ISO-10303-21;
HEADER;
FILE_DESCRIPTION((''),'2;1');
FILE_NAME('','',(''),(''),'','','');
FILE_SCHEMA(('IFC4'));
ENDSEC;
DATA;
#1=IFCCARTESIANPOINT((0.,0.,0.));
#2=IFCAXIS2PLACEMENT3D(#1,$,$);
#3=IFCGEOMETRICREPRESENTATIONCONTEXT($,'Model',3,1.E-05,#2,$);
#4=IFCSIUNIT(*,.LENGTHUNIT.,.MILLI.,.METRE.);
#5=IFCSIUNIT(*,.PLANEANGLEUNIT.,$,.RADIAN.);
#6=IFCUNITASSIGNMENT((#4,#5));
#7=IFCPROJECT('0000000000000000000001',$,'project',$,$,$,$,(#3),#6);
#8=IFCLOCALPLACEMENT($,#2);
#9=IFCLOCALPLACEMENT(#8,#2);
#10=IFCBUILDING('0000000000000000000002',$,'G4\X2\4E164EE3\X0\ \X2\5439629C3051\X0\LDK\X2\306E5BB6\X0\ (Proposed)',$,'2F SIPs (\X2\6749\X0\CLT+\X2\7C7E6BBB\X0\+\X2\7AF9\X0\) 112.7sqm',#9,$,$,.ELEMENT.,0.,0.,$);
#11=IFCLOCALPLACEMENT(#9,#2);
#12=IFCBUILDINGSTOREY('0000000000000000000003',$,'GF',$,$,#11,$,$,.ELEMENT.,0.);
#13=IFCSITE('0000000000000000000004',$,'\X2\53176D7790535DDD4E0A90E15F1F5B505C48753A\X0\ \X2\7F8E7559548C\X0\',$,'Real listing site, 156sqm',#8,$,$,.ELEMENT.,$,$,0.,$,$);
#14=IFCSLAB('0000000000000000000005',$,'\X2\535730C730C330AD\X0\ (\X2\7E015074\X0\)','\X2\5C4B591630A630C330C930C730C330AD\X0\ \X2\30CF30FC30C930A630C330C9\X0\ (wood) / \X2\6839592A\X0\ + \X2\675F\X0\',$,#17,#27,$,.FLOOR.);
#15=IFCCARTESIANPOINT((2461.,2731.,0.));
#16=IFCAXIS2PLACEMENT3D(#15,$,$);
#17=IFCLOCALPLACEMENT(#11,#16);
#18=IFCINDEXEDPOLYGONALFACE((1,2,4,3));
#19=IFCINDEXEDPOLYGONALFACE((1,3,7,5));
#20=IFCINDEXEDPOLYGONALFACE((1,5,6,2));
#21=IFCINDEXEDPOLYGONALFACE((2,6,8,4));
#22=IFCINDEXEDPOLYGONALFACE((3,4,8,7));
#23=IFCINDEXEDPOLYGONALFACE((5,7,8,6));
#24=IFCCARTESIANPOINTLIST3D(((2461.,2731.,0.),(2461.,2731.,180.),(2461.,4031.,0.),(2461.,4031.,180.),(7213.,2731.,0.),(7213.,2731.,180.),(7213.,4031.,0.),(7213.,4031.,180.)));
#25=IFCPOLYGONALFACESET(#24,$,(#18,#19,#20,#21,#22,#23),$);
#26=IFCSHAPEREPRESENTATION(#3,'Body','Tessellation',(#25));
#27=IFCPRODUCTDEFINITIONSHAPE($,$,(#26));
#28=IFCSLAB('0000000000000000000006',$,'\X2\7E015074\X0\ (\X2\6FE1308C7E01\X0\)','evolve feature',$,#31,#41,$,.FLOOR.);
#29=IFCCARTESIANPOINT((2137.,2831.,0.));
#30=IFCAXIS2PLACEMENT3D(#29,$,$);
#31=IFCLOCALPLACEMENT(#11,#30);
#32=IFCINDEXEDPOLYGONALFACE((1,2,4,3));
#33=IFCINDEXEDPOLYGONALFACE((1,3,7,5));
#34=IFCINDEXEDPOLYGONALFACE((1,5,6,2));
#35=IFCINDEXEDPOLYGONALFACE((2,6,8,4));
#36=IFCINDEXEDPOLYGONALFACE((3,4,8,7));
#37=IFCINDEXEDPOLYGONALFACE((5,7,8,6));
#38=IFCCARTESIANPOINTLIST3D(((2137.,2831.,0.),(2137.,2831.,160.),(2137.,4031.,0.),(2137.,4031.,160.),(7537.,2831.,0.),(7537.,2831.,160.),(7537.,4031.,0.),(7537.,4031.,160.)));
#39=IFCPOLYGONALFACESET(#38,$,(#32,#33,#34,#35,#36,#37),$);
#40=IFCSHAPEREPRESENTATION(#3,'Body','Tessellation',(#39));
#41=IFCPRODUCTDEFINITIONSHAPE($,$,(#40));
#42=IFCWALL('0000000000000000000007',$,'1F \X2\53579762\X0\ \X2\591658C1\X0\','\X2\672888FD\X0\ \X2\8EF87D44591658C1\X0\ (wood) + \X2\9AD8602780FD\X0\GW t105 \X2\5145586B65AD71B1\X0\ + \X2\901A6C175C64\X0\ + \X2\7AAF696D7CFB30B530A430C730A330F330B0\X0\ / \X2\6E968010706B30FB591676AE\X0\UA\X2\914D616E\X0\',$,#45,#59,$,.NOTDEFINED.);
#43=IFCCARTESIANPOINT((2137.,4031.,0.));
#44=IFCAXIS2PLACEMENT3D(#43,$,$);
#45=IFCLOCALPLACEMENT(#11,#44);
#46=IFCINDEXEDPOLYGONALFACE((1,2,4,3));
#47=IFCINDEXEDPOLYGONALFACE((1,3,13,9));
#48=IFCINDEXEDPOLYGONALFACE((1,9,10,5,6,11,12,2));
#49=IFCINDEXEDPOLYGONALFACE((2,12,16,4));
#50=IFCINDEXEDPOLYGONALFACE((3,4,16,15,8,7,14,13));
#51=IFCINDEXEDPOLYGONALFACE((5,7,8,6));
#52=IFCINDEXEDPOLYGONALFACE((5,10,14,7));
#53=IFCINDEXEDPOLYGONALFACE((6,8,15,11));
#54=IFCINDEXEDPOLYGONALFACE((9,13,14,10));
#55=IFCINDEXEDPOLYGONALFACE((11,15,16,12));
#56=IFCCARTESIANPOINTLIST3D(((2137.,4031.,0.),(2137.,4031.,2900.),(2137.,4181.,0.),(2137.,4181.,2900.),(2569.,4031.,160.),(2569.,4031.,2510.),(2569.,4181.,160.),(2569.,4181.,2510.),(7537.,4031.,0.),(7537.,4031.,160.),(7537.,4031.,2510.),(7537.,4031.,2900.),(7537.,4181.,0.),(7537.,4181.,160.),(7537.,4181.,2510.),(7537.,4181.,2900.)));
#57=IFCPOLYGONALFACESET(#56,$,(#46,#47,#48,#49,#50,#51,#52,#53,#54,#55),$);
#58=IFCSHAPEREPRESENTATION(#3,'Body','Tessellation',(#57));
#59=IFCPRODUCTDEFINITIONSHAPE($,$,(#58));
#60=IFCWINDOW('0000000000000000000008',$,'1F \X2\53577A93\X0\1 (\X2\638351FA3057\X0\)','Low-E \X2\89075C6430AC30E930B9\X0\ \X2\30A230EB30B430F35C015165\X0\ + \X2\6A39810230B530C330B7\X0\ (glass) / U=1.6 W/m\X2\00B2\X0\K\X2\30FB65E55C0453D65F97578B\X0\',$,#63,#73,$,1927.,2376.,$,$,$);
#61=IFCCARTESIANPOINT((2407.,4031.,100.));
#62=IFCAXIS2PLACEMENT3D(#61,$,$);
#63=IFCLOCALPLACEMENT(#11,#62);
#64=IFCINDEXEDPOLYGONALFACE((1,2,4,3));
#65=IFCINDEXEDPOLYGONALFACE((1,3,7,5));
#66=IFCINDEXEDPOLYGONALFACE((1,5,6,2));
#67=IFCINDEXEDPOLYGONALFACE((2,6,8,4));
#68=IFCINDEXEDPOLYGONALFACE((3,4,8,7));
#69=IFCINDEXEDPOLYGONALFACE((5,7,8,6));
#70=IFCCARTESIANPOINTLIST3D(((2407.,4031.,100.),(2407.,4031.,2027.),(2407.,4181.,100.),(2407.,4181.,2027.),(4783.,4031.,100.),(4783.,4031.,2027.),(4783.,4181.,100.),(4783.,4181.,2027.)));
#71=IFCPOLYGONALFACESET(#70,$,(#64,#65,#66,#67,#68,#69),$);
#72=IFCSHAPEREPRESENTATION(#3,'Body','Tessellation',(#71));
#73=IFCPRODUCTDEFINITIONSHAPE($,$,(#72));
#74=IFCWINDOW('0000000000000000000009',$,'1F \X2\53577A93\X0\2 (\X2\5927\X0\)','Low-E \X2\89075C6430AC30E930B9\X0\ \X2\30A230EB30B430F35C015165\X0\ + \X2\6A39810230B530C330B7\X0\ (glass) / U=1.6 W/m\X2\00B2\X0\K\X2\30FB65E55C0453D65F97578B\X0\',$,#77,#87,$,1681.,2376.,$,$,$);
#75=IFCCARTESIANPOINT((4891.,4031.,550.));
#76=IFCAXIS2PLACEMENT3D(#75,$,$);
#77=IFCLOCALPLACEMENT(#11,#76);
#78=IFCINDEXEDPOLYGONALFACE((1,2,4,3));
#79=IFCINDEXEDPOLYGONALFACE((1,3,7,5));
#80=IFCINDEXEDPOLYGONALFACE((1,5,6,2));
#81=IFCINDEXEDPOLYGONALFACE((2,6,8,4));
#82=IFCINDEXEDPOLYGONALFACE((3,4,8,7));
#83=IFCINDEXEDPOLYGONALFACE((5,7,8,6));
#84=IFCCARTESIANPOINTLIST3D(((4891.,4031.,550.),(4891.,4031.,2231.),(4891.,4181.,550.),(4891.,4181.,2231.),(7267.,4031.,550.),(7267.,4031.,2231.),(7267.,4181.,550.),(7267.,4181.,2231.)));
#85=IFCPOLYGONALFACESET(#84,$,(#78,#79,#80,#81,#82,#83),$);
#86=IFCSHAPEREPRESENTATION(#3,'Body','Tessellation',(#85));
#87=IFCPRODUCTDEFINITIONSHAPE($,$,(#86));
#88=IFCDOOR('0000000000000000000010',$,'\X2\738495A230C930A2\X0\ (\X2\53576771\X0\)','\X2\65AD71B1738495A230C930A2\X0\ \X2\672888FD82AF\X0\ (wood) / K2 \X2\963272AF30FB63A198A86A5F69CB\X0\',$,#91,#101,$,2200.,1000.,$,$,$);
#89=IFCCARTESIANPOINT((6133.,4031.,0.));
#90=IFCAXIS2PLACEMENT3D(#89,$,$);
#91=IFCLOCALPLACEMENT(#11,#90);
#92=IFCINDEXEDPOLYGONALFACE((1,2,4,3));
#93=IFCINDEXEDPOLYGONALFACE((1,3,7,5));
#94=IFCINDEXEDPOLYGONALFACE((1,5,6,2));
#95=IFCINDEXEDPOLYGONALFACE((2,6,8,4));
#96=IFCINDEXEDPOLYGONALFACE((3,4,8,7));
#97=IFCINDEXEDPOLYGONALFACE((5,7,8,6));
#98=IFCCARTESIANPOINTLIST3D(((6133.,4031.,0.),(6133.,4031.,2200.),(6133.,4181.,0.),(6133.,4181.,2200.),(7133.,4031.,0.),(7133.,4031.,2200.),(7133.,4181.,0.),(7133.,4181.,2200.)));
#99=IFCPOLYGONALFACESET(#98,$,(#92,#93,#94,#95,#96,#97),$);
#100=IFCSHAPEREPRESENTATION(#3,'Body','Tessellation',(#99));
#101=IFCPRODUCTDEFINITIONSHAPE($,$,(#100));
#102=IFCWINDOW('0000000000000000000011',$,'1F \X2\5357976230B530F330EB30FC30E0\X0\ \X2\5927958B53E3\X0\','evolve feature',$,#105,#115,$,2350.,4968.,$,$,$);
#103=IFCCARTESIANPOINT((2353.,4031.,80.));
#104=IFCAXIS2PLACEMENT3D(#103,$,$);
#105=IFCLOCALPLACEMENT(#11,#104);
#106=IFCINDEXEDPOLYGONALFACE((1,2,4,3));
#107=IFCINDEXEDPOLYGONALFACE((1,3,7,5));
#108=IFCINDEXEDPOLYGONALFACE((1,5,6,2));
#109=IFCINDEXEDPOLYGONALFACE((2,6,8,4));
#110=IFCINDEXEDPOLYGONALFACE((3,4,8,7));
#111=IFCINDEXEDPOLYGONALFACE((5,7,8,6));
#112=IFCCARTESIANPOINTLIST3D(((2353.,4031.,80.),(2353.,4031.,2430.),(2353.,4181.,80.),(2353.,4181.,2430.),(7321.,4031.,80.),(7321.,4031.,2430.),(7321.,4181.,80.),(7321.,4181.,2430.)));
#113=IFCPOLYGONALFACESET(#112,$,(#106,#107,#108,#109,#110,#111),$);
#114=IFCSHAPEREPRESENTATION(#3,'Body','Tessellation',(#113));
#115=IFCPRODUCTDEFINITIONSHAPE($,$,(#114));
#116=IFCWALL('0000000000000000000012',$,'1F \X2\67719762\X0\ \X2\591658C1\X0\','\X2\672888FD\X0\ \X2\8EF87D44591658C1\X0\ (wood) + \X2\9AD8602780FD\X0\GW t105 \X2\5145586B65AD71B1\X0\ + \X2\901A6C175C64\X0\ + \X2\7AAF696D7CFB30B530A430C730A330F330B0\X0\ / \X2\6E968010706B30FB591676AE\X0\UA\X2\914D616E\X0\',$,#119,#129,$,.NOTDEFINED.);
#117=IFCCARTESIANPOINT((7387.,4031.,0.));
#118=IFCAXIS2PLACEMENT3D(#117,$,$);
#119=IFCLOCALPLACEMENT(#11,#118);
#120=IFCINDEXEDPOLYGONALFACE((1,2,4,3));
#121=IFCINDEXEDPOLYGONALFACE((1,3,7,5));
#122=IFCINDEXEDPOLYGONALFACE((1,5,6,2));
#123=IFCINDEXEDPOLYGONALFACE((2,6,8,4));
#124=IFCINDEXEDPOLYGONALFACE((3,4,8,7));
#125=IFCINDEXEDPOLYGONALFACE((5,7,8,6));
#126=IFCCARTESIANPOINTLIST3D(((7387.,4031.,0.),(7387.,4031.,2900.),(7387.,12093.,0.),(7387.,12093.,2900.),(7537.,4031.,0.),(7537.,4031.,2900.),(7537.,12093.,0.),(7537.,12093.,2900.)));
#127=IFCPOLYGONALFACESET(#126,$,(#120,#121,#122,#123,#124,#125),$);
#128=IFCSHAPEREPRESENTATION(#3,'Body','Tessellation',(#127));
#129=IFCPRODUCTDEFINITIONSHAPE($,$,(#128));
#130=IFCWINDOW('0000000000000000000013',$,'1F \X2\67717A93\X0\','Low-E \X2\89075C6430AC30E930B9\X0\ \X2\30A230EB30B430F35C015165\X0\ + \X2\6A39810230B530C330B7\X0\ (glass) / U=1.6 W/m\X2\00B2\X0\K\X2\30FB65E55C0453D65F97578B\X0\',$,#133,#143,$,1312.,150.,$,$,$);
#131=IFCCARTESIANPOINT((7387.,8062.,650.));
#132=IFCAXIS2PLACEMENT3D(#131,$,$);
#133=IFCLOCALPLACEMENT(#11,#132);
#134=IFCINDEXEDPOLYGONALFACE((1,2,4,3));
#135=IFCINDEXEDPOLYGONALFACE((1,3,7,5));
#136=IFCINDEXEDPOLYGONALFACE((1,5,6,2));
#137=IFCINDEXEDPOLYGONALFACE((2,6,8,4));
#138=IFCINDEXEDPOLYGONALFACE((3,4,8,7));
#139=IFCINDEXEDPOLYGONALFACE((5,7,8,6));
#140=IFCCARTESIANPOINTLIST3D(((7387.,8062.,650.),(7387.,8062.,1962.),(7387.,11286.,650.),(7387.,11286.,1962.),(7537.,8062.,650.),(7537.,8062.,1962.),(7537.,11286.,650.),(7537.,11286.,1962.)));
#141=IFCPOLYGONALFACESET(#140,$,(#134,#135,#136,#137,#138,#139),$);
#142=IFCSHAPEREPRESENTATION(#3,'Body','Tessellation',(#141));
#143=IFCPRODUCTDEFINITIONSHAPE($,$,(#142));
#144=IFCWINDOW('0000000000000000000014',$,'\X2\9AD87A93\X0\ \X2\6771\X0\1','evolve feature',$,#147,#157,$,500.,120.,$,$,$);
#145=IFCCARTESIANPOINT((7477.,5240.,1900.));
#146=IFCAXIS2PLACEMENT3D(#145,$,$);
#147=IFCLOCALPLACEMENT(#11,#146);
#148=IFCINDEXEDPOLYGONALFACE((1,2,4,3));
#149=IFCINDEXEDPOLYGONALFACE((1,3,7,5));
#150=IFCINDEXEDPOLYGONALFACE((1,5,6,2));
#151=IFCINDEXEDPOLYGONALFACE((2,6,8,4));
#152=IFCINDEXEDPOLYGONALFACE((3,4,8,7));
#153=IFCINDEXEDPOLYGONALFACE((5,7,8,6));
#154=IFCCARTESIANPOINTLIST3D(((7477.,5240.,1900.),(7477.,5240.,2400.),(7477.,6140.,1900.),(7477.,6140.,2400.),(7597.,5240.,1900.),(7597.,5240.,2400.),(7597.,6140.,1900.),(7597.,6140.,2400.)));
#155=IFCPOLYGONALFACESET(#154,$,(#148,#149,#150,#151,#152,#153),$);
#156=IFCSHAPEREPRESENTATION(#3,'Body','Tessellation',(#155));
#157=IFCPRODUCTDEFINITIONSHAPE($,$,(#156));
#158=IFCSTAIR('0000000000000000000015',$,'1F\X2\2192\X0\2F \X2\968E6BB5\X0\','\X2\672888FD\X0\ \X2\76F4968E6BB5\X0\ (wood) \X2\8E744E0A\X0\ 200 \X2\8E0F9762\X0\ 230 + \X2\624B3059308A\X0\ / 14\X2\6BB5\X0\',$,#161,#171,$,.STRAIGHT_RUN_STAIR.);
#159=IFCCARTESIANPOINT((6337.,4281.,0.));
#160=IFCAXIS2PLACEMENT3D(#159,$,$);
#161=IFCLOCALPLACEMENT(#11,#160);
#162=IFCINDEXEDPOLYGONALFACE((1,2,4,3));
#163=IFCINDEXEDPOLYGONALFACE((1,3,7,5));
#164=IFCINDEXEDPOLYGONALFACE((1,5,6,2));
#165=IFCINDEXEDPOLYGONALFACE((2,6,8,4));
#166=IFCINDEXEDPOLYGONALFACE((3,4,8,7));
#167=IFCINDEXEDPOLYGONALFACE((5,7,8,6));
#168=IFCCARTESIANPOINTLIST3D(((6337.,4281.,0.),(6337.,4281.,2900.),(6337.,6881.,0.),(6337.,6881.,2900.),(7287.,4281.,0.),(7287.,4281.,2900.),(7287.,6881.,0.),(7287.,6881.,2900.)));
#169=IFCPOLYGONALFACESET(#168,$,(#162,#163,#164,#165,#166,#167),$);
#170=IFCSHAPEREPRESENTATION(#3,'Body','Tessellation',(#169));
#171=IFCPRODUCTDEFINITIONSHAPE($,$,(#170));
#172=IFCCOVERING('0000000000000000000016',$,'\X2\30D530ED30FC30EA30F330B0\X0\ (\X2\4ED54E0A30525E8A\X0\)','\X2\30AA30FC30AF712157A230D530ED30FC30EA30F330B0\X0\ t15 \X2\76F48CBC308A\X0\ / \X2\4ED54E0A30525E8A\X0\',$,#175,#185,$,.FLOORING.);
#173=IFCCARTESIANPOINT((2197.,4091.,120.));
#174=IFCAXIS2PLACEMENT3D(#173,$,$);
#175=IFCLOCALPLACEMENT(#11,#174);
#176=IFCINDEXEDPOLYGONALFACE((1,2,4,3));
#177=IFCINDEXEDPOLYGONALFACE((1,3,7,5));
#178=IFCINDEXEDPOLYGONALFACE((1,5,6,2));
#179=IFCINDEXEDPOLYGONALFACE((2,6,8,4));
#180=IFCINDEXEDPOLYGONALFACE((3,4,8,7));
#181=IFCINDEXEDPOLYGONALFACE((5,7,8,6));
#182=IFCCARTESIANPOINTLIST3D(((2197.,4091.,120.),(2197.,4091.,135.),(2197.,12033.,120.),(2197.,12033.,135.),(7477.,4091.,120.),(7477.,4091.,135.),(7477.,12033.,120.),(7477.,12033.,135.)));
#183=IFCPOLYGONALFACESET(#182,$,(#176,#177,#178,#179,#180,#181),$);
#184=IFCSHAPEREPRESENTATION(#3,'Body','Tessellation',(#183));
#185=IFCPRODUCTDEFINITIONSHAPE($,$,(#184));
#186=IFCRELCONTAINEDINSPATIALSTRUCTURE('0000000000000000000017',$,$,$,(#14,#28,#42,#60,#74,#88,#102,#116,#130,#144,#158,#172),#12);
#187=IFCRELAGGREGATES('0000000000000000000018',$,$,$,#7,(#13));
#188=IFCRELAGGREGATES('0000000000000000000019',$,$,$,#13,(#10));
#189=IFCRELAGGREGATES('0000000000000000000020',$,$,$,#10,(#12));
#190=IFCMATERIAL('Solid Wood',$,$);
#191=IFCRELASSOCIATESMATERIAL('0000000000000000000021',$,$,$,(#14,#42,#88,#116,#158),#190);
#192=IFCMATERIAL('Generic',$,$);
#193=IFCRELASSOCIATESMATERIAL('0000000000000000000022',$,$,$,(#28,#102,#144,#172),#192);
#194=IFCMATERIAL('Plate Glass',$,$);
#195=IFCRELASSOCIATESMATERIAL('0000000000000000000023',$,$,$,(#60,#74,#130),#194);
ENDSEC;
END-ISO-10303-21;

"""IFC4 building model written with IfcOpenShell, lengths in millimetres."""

from ifc_helpers import new_model, si_unit, frame, frame_2d, origin, place, context, project, spatial, rectangle, extrude, material, element, fill, save


model = new_model("IFC4")

# Units and contexts
model_context = context("Model", 3, precision=1e-05, world=origin())
ifc_project = project(units=[si_unit("LENGTHUNIT", "METRE", prefix="MILLI"), si_unit("PLANEANGLEUNIT", "RADIAN")], contexts=[model_context])

# Site, building, storey
site_placement = place(None, origin())
site = spatial("IfcSite", under=ifc_project, at=site_placement, Name="北海道川上郡弟子屈町 美留和", ObjectType="Real listing site, 156sqm", CompositionType="ELEMENT", RefElevation=0.0)
building_placement = place(site_placement, origin())
building = spatial("IfcBuilding", under=site, at=building_placement, Name="G4世代 吹抜けLDKの家 (Proposed)", ObjectType="2F SIPs (杉CLT+籾殻+竹) 112.7sqm", CompositionType="ELEMENT", ElevationOfRefHeight=0.0, ElevationOfTerrain=0.0)
storey_placement = place(building_placement, origin())
storey = spatial("IfcBuildingStorey", under=building, at=storey_placement, Name="GF", CompositionType="ELEMENT", Elevation=0.0)

# Slabs
ifc_material_1 = material(Name="Solid Wood")
slab_1_placement = place(storey_placement, frame((2461.0, 2731.0, 0.0)))
element("IfcSlab", 1, at=slab_1_placement, inside=storey, material=ifc_material_1, Name="南デッキ (縁側)", Description="屋外ウッドデッキ ハードウッド (wood) / 根太 + 束", PredefinedType="FLOOR", context=model_context, shape_type="SweptSolid", body=[
    extrude(rectangle(XDim=4752.0, YDim=1300.0, at=frame_2d((2376.0, 650.0))), frame((2461.0, 2731.0, 0.0)), (0.0, 0.0, 1.0), 180.0),
])
ifc_material_2 = material(Name="Generic")
slab_2_placement = place(storey_placement, frame((2137.0, 2831.0, 0.0)))
element("IfcSlab", 2, at=slab_2_placement, inside=storey, material=ifc_material_2, Name="縁側 (濡れ縁)", Description="evolve feature", PredefinedType="FLOOR", context=model_context, shape_type="SweptSolid", body=[
    extrude(rectangle(XDim=5400.0, YDim=1200.0, at=frame_2d((2700.0, 600.0))), frame((2137.0, 2831.0, 0.0)), (0.0, 0.0, 1.0), 160.0),
])

# Wall, openings, windows, door
wall_1_placement = place(storey_placement, frame((2137.0, 4031.0, 0.0)))
wall_1 = element("IfcWall", 3, at=wall_1_placement, inside=storey, material=ifc_material_1, Name="1F 南面 外壁", Description="木製 軸組外壁 (wood) + 高性能GW t105 充填断熱 + 通気層 + 窯業系サイディング / 準耐火・外皮UA配慮", PredefinedType="NOTDEFINED", context=model_context, shape_type="SweptSolid", body=[
    extrude(rectangle(XDim=5400.0, YDim=150.0, at=frame_2d((2700.0, 75.0))), frame((2137.0, 4031.0, 0.0)), (0.0, 0.0, 1.0), 2900.0),
])
opening_1_placement = place(storey_placement, frame((2407.0, 4031.0, 100.0)))
opening_1 = element("IfcOpeningElement", 4, at=opening_1_placement, cuts=wall_1, PredefinedType="NOTDEFINED", context=model_context, shape_type="SweptSolid", body=[
    extrude(rectangle(XDim=2376.0, YDim=150.0, at=frame_2d((1188.0, 75.0))), frame((2407.0, 4031.0, 100.0)), (0.0, 0.0, 1.0), 1927.0),
])
opening_2_placement = place(storey_placement, frame((4891.0, 4031.0, 550.0)))
opening_2 = element("IfcOpeningElement", 5, at=opening_2_placement, cuts=wall_1, PredefinedType="NOTDEFINED", context=model_context, shape_type="SweptSolid", body=[
    extrude(rectangle(XDim=2376.0, YDim=150.0, at=frame_2d((1188.0, 75.0))), frame((4891.0, 4031.0, 550.0)), (0.0, 0.0, 1.0), 1681.0),
])
opening_3_placement = place(storey_placement, frame((6133.0, 4031.0, 0.0)))
opening_3 = element("IfcOpeningElement", 6, at=opening_3_placement, cuts=wall_1, PredefinedType="NOTDEFINED", context=model_context, shape_type="SweptSolid", body=[
    extrude(rectangle(XDim=1000.0, YDim=150.0, at=frame_2d((500.0, 75.0))), frame((6133.0, 4031.0, 0.0)), (0.0, 0.0, 1.0), 2200.0),
])
opening_4_placement = place(storey_placement, frame((2353.0, 4031.0, 80.0)))
opening_4 = element("IfcOpeningElement", 7, at=opening_4_placement, cuts=wall_1, PredefinedType="NOTDEFINED", context=model_context, shape_type="SweptSolid", body=[
    extrude(rectangle(XDim=4968.0, YDim=150.0, at=frame_2d((2484.0, 75.0))), frame((2353.0, 4031.0, 80.0)), (0.0, 0.0, 1.0), 2350.0),
])
ifc_material_3 = material(Name="Plate Glass")
window_1_placement = place(storey_placement, frame((2407.0, 4031.0, 100.0)))
window_1 = element("IfcWindow", 8, at=window_1_placement, inside=storey, material=ifc_material_3, Name="1F 南窓1 (掃出し)", Description="Low-E 複層ガラス アルゴン封入 + 樹脂サッシ (glass) / U=1.6 W/m²K・日射取得型", OverallHeight=1927.0, OverallWidth=2376.0, context=model_context, shape_type="SweptSolid", body=[
    extrude(rectangle(XDim=2376.0, YDim=150.0, at=frame_2d((1188.0, 75.0))), frame((2407.0, 4031.0, 100.0)), (0.0, 0.0, 1.0), 1927.0),
])
fill(opening_1, window_1)
window_2_placement = place(storey_placement, frame((4891.0, 4031.0, 550.0)))
window_2 = element("IfcWindow", 9, at=window_2_placement, inside=storey, material=ifc_material_3, Name="1F 南窓2 (大)", Description="Low-E 複層ガラス アルゴン封入 + 樹脂サッシ (glass) / U=1.6 W/m²K・日射取得型", OverallHeight=1681.0, OverallWidth=2376.0, context=model_context, shape_type="SweptSolid", body=[
    extrude(rectangle(XDim=2376.0, YDim=150.0, at=frame_2d((1188.0, 75.0))), frame((4891.0, 4031.0, 550.0)), (0.0, 0.0, 1.0), 1681.0),
])
fill(opening_2, window_2)
door_placement = place(storey_placement, frame((6133.0, 4031.0, 0.0)))
door = element("IfcDoor", 10, at=door_placement, inside=storey, material=ifc_material_1, Name="玄関ドア (南東)", Description="断熱玄関ドア 木製芯 (wood) / K2 防犯・採風機構", OverallHeight=2200.0, OverallWidth=1000.0, context=model_context, shape_type="SweptSolid", body=[
    extrude(rectangle(XDim=1000.0, YDim=150.0, at=frame_2d((500.0, 75.0))), frame((6133.0, 4031.0, 0.0)), (0.0, 0.0, 1.0), 2200.0),
])
fill(opening_3, door)
window_3_placement = place(storey_placement, frame((2353.0, 4031.0, 80.0)))
window_3 = element("IfcWindow", 11, at=window_3_placement, inside=storey, material=ifc_material_2, Name="1F 南面サンルーム 大開口", Description="evolve feature", OverallHeight=2350.0, OverallWidth=4968.0, context=model_context, shape_type="SweptSolid", body=[
    extrude(rectangle(XDim=4968.0, YDim=150.0, at=frame_2d((2484.0, 75.0))), frame((2353.0, 4031.0, 80.0)), (0.0, 0.0, 1.0), 2350.0),
])
fill(opening_4, window_3)

# Wall, openings, windows
wall_2_placement = place(storey_placement, frame((7387.0, 4031.0, 0.0)))
wall_2 = element("IfcWall", 12, at=wall_2_placement, inside=storey, material=ifc_material_1, Name="1F 東面 外壁", Description="木製 軸組外壁 (wood) + 高性能GW t105 充填断熱 + 通気層 + 窯業系サイディング / 準耐火・外皮UA配慮", PredefinedType="NOTDEFINED", context=model_context, shape_type="SweptSolid", body=[
    extrude(rectangle(XDim=150.0, YDim=8062.0, at=frame_2d((75.0, 4031.0))), frame((7387.0, 4031.0, 0.0)), (0.0, 0.0, 1.0), 2900.0),
])
opening_5_placement = place(storey_placement, frame((7387.0, 8062.0, 650.0)))
opening_5 = element("IfcOpeningElement", 13, at=opening_5_placement, cuts=wall_2, PredefinedType="NOTDEFINED", context=model_context, shape_type="SweptSolid", body=[
    extrude(rectangle(XDim=150.0, YDim=3224.0, at=frame_2d((75.0, 1612.0))), frame((7387.0, 8062.0, 650.0)), (0.0, 0.0, 1.0), 1312.0),
])
opening_6_placement = place(storey_placement, frame((7477.0, 5240.0, 1900.0)))
opening_6 = element("IfcOpeningElement", 14, at=opening_6_placement, cuts=wall_2, PredefinedType="NOTDEFINED", context=model_context, shape_type="SweptSolid", body=[
    extrude(rectangle(XDim=120.0, YDim=900.0, at=frame_2d((60.0, 450.0))), frame((7477.0, 5240.0, 1900.0)), (0.0, 0.0, 1.0), 500.0),
])
window_4_placement = place(storey_placement, frame((7387.0, 8062.0, 650.0)))
window_4 = element("IfcWindow", 15, at=window_4_placement, inside=storey, material=ifc_material_3, Name="1F 東窓", Description="Low-E 複層ガラス アルゴン封入 + 樹脂サッシ (glass) / U=1.6 W/m²K・日射取得型", OverallHeight=1312.0, OverallWidth=150.0, context=model_context, shape_type="SweptSolid", body=[
    extrude(rectangle(XDim=150.0, YDim=3224.0, at=frame_2d((75.0, 1612.0))), frame((7387.0, 8062.0, 650.0)), (0.0, 0.0, 1.0), 1312.0),
])
fill(opening_5, window_4)
window_5_placement = place(storey_placement, frame((7477.0, 5240.0, 1900.0)))
window_5 = element("IfcWindow", 16, at=window_5_placement, inside=storey, material=ifc_material_2, Name="高窓 東1", Description="evolve feature", OverallHeight=500.0, OverallWidth=120.0, context=model_context, shape_type="SweptSolid", body=[
    extrude(rectangle(XDim=120.0, YDim=900.0, at=frame_2d((60.0, 450.0))), frame((7477.0, 5240.0, 1900.0)), (0.0, 0.0, 1.0), 500.0),
])
fill(opening_6, window_5)

# Stair
stair_placement = place(storey_placement, frame((6337.0, 4281.0, 0.0)))
element("IfcStair", 17, at=stair_placement, inside=storey, material=ifc_material_1, Name="1F→2F 階段", Description="木製 直階段 (wood) 蹴上 200 踏面 230 + 手すり / 14段", PredefinedType="STRAIGHT_RUN_STAIR", context=model_context, shape_type="SweptSolid", body=[
    extrude(rectangle(XDim=950.0, YDim=2600.0, at=frame_2d((475.0, 1300.0))), frame((6337.0, 4281.0, 0.0)), (0.0, 0.0, 1.0), 2900.0),
])

# Covering
covering_placement = place(storey_placement, frame((2197.0, 4091.0, 120.0)))
element("IfcCovering", 18, at=covering_placement, inside=storey, material=ifc_material_2, Name="フローリング (仕上げ床)", Description="オーク無垢フローリング t15 直貼り / 仕上げ床", PredefinedType="FLOORING", context=model_context, shape_type="SweptSolid", body=[
    extrude(rectangle(XDim=5280.0, YDim=7942.0, at=frame_2d((2640.0, 3971.0))), frame((2197.0, 4091.0, 120.0)), (0.0, 0.0, 1.0), 15.0),
])

save(model, "model.ifc")
